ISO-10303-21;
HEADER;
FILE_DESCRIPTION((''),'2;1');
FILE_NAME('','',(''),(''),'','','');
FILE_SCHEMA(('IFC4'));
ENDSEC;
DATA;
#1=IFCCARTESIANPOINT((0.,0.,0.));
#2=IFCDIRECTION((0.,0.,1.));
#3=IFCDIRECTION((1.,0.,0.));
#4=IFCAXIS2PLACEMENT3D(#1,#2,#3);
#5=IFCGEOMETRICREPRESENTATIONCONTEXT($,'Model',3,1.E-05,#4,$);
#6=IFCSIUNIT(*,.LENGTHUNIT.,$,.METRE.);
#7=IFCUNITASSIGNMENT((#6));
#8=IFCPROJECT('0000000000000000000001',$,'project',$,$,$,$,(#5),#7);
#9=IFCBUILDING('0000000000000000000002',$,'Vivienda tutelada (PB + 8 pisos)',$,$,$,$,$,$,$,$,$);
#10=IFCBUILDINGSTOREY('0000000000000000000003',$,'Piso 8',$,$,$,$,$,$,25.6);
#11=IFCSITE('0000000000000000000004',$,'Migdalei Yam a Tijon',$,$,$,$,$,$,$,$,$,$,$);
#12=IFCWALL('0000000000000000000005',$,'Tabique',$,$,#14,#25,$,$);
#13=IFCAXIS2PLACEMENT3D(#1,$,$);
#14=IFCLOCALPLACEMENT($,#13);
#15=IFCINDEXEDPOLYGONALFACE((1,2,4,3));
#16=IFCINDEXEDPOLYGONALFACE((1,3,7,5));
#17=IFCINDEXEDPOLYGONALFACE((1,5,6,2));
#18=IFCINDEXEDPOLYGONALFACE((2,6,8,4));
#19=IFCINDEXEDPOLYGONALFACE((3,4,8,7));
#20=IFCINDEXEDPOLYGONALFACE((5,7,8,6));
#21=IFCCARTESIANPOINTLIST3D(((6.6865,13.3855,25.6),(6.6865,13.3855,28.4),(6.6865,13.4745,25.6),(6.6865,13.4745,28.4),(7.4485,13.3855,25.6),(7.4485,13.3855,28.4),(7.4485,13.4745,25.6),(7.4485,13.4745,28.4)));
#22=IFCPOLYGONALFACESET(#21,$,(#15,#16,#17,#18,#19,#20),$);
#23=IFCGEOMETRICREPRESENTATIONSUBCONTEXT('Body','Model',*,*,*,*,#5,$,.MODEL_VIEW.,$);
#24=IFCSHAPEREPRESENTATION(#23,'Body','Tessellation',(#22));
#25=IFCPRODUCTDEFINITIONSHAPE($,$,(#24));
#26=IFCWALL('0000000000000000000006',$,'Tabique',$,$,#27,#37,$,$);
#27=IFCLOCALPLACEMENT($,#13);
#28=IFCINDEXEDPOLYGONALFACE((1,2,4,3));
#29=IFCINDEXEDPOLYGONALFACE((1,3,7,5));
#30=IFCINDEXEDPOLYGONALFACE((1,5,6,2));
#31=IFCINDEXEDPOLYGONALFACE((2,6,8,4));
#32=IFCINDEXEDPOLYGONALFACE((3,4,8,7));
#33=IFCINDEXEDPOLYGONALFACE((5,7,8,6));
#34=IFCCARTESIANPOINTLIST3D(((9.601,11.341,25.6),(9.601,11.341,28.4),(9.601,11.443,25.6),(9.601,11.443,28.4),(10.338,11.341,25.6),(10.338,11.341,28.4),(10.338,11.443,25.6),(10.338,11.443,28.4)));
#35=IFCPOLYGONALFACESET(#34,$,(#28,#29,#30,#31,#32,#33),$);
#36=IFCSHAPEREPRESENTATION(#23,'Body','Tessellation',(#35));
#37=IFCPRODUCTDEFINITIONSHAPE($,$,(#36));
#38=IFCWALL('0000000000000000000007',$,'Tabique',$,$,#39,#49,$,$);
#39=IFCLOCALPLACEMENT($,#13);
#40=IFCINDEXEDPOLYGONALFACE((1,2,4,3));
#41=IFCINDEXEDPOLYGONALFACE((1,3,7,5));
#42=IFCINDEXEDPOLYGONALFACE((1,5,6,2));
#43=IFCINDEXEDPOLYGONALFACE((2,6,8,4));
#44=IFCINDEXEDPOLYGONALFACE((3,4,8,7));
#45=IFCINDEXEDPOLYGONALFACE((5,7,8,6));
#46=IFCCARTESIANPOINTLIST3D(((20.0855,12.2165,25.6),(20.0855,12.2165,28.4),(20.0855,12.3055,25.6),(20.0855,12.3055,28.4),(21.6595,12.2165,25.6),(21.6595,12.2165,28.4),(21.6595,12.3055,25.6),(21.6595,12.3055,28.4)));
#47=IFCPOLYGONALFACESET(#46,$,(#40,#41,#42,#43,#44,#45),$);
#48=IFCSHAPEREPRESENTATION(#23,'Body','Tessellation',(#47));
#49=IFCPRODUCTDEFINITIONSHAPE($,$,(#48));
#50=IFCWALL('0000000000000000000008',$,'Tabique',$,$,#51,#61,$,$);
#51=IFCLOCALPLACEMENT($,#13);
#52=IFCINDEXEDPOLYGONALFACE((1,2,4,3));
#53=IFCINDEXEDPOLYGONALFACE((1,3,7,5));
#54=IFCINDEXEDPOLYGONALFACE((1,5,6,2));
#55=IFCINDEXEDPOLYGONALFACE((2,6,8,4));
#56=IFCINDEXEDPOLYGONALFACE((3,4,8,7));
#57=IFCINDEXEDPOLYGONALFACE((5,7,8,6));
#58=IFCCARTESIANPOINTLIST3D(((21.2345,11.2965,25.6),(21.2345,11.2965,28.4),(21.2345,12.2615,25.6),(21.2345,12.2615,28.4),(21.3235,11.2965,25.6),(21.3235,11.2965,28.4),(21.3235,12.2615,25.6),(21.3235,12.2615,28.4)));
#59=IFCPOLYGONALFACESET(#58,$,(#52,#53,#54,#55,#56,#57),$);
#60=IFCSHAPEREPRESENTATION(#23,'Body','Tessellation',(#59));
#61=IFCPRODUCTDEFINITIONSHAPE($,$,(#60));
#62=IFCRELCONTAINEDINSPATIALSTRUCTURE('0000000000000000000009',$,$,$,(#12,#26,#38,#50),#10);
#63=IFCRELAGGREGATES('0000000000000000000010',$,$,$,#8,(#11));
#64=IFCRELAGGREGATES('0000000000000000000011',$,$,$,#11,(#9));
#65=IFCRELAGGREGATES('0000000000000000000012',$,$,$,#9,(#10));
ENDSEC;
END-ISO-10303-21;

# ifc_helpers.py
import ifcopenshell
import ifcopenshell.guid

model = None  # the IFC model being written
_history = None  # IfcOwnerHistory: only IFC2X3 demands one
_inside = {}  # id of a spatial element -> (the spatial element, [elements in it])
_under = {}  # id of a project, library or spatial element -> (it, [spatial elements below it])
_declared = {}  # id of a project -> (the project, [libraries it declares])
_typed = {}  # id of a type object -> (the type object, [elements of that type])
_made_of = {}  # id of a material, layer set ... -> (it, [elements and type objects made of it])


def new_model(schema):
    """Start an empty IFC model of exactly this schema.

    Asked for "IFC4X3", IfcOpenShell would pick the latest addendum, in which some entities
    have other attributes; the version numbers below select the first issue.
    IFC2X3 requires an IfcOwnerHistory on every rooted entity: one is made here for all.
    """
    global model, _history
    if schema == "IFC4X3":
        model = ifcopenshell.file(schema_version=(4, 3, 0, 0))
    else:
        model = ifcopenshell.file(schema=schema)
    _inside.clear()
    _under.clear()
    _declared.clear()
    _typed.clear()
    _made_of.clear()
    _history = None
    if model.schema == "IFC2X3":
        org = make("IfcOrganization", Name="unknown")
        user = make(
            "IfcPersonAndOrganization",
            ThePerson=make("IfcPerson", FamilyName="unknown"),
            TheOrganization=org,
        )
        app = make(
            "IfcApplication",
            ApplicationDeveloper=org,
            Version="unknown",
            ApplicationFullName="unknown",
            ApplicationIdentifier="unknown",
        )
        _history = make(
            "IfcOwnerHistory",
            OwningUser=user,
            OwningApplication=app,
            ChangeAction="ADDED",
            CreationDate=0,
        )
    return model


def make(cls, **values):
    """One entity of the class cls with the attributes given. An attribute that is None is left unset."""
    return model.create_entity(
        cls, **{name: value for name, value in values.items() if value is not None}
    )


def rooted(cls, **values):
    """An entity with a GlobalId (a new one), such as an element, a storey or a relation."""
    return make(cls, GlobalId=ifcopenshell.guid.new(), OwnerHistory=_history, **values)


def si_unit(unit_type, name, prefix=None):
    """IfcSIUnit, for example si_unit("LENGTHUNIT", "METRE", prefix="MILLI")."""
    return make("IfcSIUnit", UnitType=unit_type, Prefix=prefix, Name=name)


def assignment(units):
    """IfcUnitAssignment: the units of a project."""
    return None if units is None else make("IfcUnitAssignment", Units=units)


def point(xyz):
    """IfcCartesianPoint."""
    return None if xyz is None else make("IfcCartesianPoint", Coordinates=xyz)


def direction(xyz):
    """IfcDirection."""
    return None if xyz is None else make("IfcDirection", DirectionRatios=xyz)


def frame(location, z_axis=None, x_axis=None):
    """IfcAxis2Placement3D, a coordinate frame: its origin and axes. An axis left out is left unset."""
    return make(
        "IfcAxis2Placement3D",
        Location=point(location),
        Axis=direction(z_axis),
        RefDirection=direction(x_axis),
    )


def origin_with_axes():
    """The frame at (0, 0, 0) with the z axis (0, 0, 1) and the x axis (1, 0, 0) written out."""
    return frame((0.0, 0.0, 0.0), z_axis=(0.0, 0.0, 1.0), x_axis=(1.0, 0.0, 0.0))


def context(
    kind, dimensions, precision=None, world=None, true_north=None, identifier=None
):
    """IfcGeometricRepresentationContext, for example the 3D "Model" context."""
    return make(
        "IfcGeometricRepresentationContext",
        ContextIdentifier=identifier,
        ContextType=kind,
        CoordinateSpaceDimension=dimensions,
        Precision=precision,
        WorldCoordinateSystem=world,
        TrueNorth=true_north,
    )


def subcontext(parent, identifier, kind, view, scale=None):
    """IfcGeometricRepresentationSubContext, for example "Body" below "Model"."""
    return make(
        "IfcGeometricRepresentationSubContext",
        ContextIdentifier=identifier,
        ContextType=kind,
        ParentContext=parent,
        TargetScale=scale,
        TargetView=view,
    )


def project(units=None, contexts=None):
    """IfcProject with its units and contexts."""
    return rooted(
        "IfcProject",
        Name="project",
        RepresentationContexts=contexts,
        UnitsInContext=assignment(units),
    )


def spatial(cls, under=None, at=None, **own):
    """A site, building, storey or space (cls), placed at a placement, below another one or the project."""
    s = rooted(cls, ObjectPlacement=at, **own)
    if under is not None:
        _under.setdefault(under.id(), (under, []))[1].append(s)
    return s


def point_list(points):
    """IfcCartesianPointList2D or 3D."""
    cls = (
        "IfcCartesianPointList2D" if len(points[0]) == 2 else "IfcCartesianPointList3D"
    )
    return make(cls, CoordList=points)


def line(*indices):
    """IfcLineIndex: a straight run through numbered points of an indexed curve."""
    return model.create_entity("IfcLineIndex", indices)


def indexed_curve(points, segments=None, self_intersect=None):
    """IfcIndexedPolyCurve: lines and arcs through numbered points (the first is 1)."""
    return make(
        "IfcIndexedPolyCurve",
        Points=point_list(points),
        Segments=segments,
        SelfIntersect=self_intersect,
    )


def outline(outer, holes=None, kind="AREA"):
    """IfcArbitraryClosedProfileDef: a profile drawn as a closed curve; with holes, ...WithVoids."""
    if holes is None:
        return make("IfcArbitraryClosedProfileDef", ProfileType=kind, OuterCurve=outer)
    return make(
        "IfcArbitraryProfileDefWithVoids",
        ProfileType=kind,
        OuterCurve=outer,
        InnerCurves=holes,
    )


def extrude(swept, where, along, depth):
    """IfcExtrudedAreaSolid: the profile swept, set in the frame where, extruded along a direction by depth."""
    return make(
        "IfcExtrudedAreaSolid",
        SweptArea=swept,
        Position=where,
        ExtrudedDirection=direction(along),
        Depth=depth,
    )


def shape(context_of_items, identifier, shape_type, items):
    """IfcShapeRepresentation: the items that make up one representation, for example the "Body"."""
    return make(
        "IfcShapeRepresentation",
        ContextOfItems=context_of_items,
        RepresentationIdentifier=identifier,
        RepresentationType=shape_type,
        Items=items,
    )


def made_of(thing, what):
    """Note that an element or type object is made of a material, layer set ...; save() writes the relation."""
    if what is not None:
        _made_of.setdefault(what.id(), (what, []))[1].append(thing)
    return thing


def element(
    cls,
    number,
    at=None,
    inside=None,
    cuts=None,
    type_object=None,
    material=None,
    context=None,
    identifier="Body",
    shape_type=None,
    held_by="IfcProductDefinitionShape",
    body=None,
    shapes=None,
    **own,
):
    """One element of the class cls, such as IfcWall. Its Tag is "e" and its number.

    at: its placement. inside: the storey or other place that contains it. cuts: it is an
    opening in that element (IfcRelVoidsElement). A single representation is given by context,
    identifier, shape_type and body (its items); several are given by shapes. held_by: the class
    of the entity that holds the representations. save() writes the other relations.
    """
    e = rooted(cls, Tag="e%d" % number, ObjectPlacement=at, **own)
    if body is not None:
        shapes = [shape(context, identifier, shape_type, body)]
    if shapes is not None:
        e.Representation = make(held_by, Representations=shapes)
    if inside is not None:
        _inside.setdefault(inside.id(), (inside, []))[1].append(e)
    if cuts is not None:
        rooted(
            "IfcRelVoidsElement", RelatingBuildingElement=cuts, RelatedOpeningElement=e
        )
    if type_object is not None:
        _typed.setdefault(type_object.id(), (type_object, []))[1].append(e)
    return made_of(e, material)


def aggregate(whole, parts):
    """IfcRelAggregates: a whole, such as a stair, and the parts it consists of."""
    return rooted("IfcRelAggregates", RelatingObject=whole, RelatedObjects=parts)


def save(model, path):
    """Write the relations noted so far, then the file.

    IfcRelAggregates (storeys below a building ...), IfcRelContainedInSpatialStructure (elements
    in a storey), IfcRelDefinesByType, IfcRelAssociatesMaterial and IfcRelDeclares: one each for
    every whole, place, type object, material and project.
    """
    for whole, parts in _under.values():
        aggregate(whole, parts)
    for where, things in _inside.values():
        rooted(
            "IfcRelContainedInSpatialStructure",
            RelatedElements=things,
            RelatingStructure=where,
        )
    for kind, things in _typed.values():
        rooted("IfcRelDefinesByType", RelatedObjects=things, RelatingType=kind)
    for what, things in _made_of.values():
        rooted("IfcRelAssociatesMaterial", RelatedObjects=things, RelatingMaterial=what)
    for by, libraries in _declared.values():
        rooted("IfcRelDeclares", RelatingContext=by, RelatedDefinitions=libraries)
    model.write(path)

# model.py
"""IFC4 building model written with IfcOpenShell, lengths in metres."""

from ifc_helpers import new_model, si_unit, frame, origin_with_axes, context, subcontext, project, spatial, line, indexed_curve, outline, extrude, element, save


model = new_model("IFC4")

# Units and contexts
model_context = context("Model", 3, precision=1e-05, world=origin_with_axes())
body_context = subcontext(model_context, "Body", "Model", "MODEL_VIEW")
ifc_project = project(units=[si_unit("LENGTHUNIT", "METRE")], contexts=[model_context])

# Site, building, storey
site = spatial("IfcSite", under=ifc_project, Name="Migdalei Yam a Tijon")
building = spatial("IfcBuilding", under=site, Name="Vivienda tutelada (PB + 8 pisos)")
storey = spatial("IfcBuildingStorey", under=building, Name="Piso 8", Elevation=25.6)

# Walls
element("IfcWall", 1, inside=storey, Name="Tabique", context=body_context, shape_type="SweptSolid", body=[
    extrude(outline(indexed_curve([(0.0, 0.0), (0.762, 0.0), (0.762, 0.089), (0.0, 0.089)], segments=[line(1, 2, 3, 4, 1)])), frame((6.6865, 13.3855, 25.6), z_axis=(0.0, 0.0, 1.0), x_axis=(1.0, 0.0, 0.0)), (0.0, 0.0, 1.0), 2.8),
])
element("IfcWall", 2, inside=storey, Name="Tabique", context=body_context, shape_type="SweptSolid", body=[
    extrude(outline(indexed_curve([(0.0, 0.0), (0.737, 0.0), (0.737, 0.102), (0.0, 0.102)], segments=[line(1, 2, 3, 4, 1)])), frame((9.601, 11.341, 25.6), z_axis=(0.0, 0.0, 1.0), x_axis=(1.0, 0.0, 0.0)), (0.0, 0.0, 1.0), 2.8),
])
element("IfcWall", 3, inside=storey, Name="Tabique", context=body_context, shape_type="SweptSolid", body=[
    extrude(outline(indexed_curve([(0.0, 0.0), (1.574, 0.0), (1.574, 0.089), (0.0, 0.089)], segments=[line(1, 2, 3, 4, 1)])), frame((20.0855, 12.2165, 25.6), z_axis=(0.0, 0.0, 1.0), x_axis=(1.0, 0.0, 0.0)), (0.0, 0.0, 1.0), 2.8),
])
element("IfcWall", 4, inside=storey, Name="Tabique", context=body_context, shape_type="SweptSolid", body=[
    extrude(outline(indexed_curve([(0.0, 0.0), (0.089, 0.0), (0.089, 0.965), (0.0, 0.965)], segments=[line(1, 2, 3, 4, 1)])), frame((21.2345, 11.2965, 25.6), z_axis=(0.0, 0.0, 1.0), x_axis=(1.0, 0.0, 0.0)), (0.0, 0.0, 1.0), 2.8),
])

save(model, "model.ifc")
